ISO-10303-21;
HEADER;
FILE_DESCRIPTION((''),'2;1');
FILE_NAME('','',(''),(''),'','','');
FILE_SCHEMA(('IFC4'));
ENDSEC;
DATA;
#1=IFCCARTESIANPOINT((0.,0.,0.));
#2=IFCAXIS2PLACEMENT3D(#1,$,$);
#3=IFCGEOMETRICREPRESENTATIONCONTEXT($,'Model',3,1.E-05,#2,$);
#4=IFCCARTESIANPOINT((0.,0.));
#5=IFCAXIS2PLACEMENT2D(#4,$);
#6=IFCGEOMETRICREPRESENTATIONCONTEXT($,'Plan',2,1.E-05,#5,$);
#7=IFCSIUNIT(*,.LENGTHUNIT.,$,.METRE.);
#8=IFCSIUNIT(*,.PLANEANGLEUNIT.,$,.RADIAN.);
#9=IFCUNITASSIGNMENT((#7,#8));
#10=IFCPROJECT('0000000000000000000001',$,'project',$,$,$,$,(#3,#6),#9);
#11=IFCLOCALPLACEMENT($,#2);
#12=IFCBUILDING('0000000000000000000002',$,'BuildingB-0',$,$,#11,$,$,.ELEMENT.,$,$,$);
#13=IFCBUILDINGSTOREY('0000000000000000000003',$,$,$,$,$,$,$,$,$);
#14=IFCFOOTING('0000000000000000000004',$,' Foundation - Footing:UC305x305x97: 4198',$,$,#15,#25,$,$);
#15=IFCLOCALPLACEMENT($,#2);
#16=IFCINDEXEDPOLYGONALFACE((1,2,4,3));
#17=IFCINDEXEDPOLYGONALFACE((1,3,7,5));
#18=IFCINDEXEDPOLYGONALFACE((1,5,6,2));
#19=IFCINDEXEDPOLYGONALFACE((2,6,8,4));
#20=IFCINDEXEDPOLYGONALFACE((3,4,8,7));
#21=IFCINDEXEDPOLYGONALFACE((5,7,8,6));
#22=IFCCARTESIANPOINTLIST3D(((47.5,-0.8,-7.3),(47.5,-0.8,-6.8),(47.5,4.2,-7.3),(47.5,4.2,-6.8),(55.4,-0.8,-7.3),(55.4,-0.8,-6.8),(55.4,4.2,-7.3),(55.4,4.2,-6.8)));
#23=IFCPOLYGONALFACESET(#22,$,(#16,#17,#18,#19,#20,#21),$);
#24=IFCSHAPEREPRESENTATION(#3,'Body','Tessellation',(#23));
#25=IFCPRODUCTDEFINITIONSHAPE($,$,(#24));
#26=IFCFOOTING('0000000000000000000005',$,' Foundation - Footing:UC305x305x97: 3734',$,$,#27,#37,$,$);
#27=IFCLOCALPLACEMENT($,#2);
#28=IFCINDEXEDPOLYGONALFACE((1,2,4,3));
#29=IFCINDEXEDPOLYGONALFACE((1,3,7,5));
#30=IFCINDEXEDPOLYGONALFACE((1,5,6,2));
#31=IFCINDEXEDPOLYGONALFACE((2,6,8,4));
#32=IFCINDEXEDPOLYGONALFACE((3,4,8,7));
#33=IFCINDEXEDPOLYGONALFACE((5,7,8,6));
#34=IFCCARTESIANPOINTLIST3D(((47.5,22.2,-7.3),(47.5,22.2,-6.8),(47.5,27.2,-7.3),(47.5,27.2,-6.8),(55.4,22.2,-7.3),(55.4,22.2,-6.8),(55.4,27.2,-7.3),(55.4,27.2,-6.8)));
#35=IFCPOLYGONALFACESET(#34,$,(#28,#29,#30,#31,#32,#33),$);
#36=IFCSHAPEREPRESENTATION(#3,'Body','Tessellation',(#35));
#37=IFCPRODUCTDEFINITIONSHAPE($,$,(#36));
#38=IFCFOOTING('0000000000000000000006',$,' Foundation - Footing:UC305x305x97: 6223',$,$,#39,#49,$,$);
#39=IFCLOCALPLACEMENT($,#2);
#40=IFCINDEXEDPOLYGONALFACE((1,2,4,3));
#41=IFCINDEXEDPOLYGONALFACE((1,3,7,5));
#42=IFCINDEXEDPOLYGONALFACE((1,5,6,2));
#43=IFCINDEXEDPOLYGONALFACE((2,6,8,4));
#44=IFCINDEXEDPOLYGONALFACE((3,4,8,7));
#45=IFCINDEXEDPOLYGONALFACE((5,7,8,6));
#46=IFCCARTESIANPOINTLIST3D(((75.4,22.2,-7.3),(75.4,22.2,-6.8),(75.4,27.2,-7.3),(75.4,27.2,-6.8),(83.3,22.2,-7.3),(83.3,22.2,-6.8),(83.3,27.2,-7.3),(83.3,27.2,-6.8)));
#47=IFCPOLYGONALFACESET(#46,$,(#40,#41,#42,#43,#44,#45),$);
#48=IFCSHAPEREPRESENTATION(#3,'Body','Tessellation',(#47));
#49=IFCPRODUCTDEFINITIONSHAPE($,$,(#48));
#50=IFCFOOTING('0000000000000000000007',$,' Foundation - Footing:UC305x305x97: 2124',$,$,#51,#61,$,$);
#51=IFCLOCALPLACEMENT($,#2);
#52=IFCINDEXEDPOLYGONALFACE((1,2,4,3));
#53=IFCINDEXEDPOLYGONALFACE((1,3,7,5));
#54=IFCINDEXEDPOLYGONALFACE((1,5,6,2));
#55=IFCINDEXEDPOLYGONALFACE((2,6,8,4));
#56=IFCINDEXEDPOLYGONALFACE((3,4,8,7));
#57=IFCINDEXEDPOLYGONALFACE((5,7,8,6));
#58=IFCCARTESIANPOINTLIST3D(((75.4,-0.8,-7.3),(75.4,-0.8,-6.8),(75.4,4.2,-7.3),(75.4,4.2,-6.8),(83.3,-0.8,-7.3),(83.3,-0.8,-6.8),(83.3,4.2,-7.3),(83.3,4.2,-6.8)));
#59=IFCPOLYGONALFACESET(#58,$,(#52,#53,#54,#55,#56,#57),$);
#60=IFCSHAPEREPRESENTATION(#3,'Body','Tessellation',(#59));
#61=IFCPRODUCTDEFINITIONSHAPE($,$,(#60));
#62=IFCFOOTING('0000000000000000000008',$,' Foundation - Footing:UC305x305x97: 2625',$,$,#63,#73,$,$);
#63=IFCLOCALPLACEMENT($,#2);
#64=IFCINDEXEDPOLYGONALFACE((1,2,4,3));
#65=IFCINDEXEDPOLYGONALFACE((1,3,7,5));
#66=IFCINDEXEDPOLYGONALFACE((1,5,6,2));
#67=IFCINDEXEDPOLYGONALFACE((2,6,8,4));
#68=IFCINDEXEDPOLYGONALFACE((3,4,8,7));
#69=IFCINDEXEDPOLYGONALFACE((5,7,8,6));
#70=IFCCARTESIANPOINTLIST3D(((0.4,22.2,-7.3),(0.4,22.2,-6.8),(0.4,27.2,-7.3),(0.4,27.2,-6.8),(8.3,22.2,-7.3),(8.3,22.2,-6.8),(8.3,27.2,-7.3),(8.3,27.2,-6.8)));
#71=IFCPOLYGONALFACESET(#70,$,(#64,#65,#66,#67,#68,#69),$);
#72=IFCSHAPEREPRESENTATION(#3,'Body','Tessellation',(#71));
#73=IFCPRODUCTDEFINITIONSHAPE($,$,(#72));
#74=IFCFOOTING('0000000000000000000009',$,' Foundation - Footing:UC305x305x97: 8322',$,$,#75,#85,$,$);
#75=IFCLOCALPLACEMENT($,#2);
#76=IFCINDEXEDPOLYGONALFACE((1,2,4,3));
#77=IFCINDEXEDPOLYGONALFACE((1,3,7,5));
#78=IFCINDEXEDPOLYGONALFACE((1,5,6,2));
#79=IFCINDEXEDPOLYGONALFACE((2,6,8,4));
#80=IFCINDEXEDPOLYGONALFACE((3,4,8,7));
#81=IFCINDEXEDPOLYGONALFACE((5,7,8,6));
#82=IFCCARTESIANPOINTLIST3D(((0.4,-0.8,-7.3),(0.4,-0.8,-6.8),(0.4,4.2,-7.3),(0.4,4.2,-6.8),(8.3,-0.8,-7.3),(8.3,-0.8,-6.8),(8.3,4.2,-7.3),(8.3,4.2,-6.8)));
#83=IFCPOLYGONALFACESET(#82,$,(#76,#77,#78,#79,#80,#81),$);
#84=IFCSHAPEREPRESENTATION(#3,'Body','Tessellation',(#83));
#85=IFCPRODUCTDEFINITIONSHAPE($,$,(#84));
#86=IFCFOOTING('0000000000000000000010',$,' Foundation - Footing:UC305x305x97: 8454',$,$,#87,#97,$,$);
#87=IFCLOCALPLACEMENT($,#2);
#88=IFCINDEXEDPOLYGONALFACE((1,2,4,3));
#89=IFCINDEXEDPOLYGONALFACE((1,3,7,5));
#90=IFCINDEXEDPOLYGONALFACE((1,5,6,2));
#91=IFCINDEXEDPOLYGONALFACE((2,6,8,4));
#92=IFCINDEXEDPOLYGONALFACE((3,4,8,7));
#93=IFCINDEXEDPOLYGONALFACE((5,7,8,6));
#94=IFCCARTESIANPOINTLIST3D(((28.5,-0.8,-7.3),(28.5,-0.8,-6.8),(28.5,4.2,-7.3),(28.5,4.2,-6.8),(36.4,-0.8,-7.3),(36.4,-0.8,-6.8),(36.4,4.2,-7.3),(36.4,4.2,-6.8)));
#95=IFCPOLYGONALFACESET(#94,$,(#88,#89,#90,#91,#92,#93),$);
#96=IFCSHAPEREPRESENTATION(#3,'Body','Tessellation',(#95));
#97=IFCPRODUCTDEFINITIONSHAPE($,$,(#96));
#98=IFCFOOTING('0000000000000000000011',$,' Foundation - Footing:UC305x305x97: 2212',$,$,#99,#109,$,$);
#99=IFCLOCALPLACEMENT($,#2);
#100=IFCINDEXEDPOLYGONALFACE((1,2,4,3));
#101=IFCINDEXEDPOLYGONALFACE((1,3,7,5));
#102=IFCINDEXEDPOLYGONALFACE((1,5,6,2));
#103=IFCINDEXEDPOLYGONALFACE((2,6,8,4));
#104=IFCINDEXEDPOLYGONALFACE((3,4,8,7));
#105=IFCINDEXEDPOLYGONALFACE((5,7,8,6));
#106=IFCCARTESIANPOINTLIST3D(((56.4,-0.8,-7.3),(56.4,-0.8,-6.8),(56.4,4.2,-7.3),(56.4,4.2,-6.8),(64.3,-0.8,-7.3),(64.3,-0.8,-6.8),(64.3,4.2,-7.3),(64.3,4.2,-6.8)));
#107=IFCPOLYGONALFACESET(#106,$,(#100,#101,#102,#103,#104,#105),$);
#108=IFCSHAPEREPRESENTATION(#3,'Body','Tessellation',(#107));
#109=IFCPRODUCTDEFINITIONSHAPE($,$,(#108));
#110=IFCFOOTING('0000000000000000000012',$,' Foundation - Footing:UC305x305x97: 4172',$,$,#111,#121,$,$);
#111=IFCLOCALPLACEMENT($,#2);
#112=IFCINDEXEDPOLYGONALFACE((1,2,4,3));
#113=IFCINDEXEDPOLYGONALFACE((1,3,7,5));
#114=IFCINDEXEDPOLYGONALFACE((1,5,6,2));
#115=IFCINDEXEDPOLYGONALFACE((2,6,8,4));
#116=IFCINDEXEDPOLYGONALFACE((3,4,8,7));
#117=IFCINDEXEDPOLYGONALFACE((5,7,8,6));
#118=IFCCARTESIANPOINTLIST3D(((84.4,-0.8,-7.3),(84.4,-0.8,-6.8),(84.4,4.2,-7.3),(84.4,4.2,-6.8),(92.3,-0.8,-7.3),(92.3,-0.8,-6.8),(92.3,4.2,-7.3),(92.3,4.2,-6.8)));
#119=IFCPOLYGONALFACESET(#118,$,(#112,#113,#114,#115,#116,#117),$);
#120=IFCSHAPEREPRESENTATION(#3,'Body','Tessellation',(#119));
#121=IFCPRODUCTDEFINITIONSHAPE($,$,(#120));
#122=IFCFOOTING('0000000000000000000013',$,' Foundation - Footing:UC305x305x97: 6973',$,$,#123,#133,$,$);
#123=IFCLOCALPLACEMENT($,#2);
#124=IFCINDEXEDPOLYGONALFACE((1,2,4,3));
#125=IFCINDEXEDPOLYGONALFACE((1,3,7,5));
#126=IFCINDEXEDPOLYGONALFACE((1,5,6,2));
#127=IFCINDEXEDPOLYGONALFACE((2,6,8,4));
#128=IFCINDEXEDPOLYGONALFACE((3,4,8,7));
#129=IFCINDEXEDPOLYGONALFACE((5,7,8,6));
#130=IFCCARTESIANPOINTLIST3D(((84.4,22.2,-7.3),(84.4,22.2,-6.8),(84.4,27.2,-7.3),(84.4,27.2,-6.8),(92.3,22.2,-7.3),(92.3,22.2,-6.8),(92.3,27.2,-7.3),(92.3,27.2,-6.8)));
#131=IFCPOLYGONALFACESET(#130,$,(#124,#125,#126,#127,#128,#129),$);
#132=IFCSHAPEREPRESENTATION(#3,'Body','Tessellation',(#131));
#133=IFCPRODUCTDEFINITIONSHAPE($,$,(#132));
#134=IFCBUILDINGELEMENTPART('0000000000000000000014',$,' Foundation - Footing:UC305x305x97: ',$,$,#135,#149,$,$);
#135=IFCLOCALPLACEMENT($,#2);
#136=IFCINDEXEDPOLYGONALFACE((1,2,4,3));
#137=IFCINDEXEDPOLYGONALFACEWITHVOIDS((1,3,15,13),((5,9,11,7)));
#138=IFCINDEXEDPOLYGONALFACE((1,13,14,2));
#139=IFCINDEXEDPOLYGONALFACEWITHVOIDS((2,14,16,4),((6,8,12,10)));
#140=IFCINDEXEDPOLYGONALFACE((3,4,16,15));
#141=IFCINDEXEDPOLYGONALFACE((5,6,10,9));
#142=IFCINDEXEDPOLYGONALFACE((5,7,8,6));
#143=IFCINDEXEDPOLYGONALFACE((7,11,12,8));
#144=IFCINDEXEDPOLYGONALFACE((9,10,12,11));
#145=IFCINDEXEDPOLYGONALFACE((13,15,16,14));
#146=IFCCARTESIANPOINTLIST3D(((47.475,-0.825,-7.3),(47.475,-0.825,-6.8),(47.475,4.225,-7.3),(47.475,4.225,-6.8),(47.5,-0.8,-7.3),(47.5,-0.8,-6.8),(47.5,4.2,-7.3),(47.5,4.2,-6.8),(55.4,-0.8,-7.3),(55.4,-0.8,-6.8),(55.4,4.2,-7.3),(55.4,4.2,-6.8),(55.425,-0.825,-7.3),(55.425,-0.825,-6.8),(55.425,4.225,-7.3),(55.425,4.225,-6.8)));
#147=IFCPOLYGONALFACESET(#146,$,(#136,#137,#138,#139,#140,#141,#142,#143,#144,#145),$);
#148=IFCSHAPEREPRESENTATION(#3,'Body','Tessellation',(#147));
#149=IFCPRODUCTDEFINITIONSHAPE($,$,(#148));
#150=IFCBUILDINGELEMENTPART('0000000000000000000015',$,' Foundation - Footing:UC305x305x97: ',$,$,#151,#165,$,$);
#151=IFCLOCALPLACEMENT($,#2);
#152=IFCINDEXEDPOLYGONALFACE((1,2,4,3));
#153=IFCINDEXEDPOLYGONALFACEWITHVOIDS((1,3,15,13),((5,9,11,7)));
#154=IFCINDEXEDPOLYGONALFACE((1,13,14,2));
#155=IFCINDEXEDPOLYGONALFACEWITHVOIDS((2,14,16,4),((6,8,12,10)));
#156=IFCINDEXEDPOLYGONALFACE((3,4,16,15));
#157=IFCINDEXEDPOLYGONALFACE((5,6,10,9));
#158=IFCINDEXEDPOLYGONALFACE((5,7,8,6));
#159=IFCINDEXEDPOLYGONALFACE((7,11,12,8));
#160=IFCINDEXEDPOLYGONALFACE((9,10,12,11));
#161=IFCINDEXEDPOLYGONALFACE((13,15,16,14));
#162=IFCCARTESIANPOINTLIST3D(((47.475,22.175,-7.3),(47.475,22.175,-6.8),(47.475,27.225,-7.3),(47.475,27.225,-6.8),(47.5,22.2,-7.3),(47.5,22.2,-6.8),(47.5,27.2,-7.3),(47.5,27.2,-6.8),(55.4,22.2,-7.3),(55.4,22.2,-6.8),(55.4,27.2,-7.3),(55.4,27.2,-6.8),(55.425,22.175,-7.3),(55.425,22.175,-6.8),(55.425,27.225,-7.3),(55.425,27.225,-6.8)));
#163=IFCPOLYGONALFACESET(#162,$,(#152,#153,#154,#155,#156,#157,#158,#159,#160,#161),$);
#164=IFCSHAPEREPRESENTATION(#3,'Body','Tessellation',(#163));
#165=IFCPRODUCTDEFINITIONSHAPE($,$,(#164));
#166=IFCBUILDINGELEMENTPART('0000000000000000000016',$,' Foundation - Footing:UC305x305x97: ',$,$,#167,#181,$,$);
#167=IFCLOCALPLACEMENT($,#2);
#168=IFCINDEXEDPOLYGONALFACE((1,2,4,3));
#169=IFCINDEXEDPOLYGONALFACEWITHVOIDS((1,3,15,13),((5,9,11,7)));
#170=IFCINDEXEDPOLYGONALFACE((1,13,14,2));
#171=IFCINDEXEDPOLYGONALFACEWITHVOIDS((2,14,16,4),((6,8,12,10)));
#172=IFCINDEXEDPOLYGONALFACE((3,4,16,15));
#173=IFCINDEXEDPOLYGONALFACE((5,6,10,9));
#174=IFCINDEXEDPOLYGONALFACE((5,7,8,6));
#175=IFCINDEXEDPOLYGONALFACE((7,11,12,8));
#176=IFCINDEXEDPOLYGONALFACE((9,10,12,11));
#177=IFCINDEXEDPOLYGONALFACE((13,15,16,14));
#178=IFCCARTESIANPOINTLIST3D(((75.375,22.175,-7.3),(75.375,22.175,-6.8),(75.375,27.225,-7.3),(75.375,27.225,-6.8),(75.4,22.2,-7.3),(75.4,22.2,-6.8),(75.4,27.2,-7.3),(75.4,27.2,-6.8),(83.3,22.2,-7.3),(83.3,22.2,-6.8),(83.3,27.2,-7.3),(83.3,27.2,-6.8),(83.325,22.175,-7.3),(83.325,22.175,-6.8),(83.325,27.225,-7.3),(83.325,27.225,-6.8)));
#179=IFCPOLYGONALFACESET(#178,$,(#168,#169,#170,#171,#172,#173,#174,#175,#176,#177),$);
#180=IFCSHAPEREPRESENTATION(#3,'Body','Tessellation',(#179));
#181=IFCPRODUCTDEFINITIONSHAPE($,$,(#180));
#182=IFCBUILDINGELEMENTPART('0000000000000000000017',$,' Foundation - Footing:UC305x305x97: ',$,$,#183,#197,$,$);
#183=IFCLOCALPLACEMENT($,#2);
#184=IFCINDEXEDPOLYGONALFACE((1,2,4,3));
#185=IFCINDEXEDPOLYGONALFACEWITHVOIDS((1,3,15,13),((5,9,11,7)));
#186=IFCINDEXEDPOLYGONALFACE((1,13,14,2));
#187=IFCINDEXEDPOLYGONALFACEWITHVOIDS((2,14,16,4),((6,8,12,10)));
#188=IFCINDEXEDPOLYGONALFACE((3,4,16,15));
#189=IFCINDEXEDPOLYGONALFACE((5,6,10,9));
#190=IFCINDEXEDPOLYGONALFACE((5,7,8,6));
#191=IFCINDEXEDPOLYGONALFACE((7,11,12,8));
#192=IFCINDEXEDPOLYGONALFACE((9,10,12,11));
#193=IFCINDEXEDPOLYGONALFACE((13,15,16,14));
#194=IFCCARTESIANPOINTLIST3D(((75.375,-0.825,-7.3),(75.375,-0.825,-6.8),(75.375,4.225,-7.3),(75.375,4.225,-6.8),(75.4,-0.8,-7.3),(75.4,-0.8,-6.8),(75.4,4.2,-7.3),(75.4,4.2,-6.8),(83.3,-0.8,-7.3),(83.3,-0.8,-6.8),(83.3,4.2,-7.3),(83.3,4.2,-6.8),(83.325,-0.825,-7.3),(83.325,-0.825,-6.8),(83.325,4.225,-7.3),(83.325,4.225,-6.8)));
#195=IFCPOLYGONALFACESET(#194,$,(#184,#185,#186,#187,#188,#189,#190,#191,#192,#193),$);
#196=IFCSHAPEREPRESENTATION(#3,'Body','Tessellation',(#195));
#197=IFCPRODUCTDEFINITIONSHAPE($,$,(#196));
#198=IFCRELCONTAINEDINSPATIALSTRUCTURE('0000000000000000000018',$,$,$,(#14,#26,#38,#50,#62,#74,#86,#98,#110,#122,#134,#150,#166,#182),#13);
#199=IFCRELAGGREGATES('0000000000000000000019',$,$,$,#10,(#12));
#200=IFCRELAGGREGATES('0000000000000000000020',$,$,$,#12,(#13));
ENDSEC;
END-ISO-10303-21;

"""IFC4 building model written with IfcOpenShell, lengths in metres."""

from ifc_helpers import new_model, si_unit, origin, origin_2d, place, context, project, spatial, polyline, outline, extrude, element, save


model = new_model("IFC4")

# Units and contexts
model_context = context("Model", 3, precision=1e-05, world=origin())
plan_context = context("Plan", 2, precision=1e-05, world=origin_2d())
ifc_project = project(units=[si_unit("LENGTHUNIT", "METRE"), si_unit("PLANEANGLEUNIT", "RADIAN")], contexts=[model_context, plan_context])

# Building, storey
building_placement = place(None, origin())
building = spatial("IfcBuilding", under=ifc_project, at=building_placement, Name="BuildingB-0", CompositionType="ELEMENT")
storey = spatial("IfcBuildingStorey", under=building)

# Footings
element("IfcFooting", 1, inside=storey, Name=" Foundation - Footing:UC305x305x97: 4198", context=model_context, shape_type="SweptSolid", body=[
    extrude(outline(polyline([(55.4, 4.2, -7.3), (47.5, 4.2, -7.3), (47.5, -0.8, -7.3), (55.4, -0.8, -7.3), (55.4, 4.2, -7.3)])), None, (0.0, 0.0, 1.0), 0.5),
])
element("IfcFooting", 2, inside=storey, Name=" Foundation - Footing:UC305x305x97: 3734", context=model_context, shape_type="SweptSolid", body=[
    extrude(outline(polyline([(55.4, 27.2, -7.3), (47.5, 27.2, -7.3), (47.5, 22.2, -7.3), (55.4, 22.2, -7.3), (55.4, 27.2, -7.3)])), None, (0.0, 0.0, 1.0), 0.5),
])
element("IfcFooting", 3, inside=storey, Name=" Foundation - Footing:UC305x305x97: 6223", context=model_context, shape_type="SweptSolid", body=[
    extrude(outline(polyline([(83.3, 27.2, -7.3), (75.4, 27.2, -7.3), (75.4, 22.2, -7.3), (83.3, 22.2, -7.3), (83.3, 27.2, -7.3)])), None, (0.0, 0.0, 1.0), 0.5),
])
element("IfcFooting", 4, inside=storey, Name=" Foundation - Footing:UC305x305x97: 2124", context=model_context, shape_type="SweptSolid", body=[
    extrude(outline(polyline([(83.3, 4.2, -7.3), (75.4, 4.2, -7.3), (75.4, -0.8, -7.3), (83.3, -0.8, -7.3), (83.3, 4.2, -7.3)])), None, (0.0, 0.0, 1.0), 0.5),
])
element("IfcFooting", 5, inside=storey, Name=" Foundation - Footing:UC305x305x97: 2625", context=model_context, shape_type="SweptSolid", body=[
    extrude(outline(polyline([(8.3, 27.2, -7.3), (0.4, 27.2, -7.3), (0.4, 22.2, -7.3), (8.3, 22.2, -7.3), (8.3, 27.2, -7.3)])), None, (0.0, 0.0, 1.0), 0.5),
])
element("IfcFooting", 6, inside=storey, Name=" Foundation - Footing:UC305x305x97: 8322", context=model_context, shape_type="SweptSolid", body=[
    extrude(outline(polyline([(8.3, 4.2, -7.3), (0.4, 4.2, -7.3), (0.4, -0.8, -7.3), (8.3, -0.8, -7.3), (8.3, 4.2, -7.3)])), None, (0.0, 0.0, 1.0), 0.5),
])
element("IfcFooting", 7, inside=storey, Name=" Foundation - Footing:UC305x305x97: 8454", context=model_context, shape_type="SweptSolid", body=[
    extrude(outline(polyline([(36.4, 4.2, -7.3), (28.5, 4.2, -7.3), (28.5, -0.8, -7.3), (36.4, -0.8, -7.3), (36.4, 4.2, -7.3)])), None, (0.0, 0.0, 1.0), 0.5),
])
element("IfcFooting", 8, inside=storey, Name=" Foundation - Footing:UC305x305x97: 2212", context=model_context, shape_type="SweptSolid", body=[
    extrude(outline(polyline([(64.3, 4.2, -7.3), (56.4, 4.2, -7.3), (56.4, -0.8, -7.3), (64.3, -0.8, -7.3), (64.3, 4.2, -7.3)])), None, (0.0, 0.0, 1.0), 0.5),
])
element("IfcFooting", 9, inside=storey, Name=" Foundation - Footing:UC305x305x97: 4172", context=model_context, shape_type="SweptSolid", body=[
    extrude(outline(polyline([(92.3, 4.2, -7.3), (84.4, 4.2, -7.3), (84.4, -0.8, -7.3), (92.3, -0.8, -7.3), (92.3, 4.2, -7.3)])), None, (0.0, 0.0, 1.0), 0.5),
])
element("IfcFooting", 10, inside=storey, Name=" Foundation - Footing:UC305x305x97: 6973", context=model_context, shape_type="SweptSolid", body=[
    extrude(outline(polyline([(92.3, 27.2, -7.3), (84.4, 27.2, -7.3), (84.4, 22.2, -7.3), (92.3, 22.2, -7.3), (92.3, 27.2, -7.3)])), None, (0.0, 0.0, 1.0), 0.5),
])

# Building element parts, openings
building_element_part_1 = element("IfcBuildingElementPart", 11, inside=storey, Name=" Foundation - Footing:UC305x305x97: ", context=model_context, shape_type="SweptSolid", body=[
    extrude(outline(polyline([(55.425, 4.225, -7.3), (47.475, 4.225, -7.3), (47.475, -0.825, -7.3), (55.425, -0.825, -7.3), (55.425, 4.225, -7.3)])), None, (0.0, 0.0, 1.0), 0.5),
])
element("IfcOpeningElement", 12, inside=storey, cuts=building_element_part_1, context=model_context, shape_type="SweptSolid", body=[
    extrude(outline(polyline([(55.4, 4.2, -7.3), (47.5, 4.2, -7.3), (47.5, -0.8, -7.3), (55.4, -0.8, -7.3), (55.4, 4.2, -7.3)])), None, (0.0, 0.0, 1.0), 0.5),
])
building_element_part_2 = element("IfcBuildingElementPart", 13, inside=storey, Name=" Foundation - Footing:UC305x305x97: ", context=model_context, shape_type="SweptSolid", body=[
    extrude(outline(polyline([(55.425, 27.225, -7.3), (47.475, 27.225, -7.3), (47.475, 22.175, -7.3), (55.425, 22.175, -7.3), (55.425, 27.225, -7.3)])), None, (0.0, 0.0, 1.0), 0.5),
])
element("IfcOpeningElement", 14, inside=storey, cuts=building_element_part_2, context=model_context, shape_type="SweptSolid", body=[
    extrude(outline(polyline([(55.4, 27.2, -7.3), (47.5, 27.2, -7.3), (47.5, 22.2, -7.3), (55.4, 22.2, -7.3), (55.4, 27.2, -7.3)])), None, (0.0, 0.0, 1.0), 0.5),
])
building_element_part_3 = element("IfcBuildingElementPart", 15, inside=storey, Name=" Foundation - Footing:UC305x305x97: ", context=model_context, shape_type="SweptSolid", body=[
    extrude(outline(polyline([(83.325, 27.225, -7.3), (75.375, 27.225, -7.3), (75.375, 22.175, -7.3), (83.325, 22.175, -7.3), (83.325, 27.225, -7.3)])), None, (0.0, 0.0, 1.0), 0.5),
])
element("IfcOpeningElement", 16, inside=storey, cuts=building_element_part_3, context=model_context, shape_type="SweptSolid", body=[
    extrude(outline(polyline([(83.3, 27.2, -7.3), (75.4, 27.2, -7.3), (75.4, 22.2, -7.3), (83.3, 22.2, -7.3), (83.3, 27.2, -7.3)])), None, (0.0, 0.0, 1.0), 0.5),
])
building_element_part_4 = element("IfcBuildingElementPart", 17, inside=storey, Name=" Foundation - Footing:UC305x305x97: ", context=model_context, shape_type="SweptSolid", body=[
    extrude(outline(polyline([(83.325, 4.225, -7.3), (75.375, 4.225, -7.3), (75.375, -0.825, -7.3), (83.325, -0.825, -7.3), (83.325, 4.225, -7.3)])), None, (0.0, 0.0, 1.0), 0.5),
])
element("IfcOpeningElement", 18, inside=storey, cuts=building_element_part_4, context=model_context, shape_type="SweptSolid", body=[
    extrude(outline(polyline([(83.3, 4.2, -7.3), (75.4, 4.2, -7.3), (75.4, -0.8, -7.3), (83.3, -0.8, -7.3), (83.3, 4.2, -7.3)])), None, (0.0, 0.0, 1.0), 0.5),
])

save(model, "model.ifc")
